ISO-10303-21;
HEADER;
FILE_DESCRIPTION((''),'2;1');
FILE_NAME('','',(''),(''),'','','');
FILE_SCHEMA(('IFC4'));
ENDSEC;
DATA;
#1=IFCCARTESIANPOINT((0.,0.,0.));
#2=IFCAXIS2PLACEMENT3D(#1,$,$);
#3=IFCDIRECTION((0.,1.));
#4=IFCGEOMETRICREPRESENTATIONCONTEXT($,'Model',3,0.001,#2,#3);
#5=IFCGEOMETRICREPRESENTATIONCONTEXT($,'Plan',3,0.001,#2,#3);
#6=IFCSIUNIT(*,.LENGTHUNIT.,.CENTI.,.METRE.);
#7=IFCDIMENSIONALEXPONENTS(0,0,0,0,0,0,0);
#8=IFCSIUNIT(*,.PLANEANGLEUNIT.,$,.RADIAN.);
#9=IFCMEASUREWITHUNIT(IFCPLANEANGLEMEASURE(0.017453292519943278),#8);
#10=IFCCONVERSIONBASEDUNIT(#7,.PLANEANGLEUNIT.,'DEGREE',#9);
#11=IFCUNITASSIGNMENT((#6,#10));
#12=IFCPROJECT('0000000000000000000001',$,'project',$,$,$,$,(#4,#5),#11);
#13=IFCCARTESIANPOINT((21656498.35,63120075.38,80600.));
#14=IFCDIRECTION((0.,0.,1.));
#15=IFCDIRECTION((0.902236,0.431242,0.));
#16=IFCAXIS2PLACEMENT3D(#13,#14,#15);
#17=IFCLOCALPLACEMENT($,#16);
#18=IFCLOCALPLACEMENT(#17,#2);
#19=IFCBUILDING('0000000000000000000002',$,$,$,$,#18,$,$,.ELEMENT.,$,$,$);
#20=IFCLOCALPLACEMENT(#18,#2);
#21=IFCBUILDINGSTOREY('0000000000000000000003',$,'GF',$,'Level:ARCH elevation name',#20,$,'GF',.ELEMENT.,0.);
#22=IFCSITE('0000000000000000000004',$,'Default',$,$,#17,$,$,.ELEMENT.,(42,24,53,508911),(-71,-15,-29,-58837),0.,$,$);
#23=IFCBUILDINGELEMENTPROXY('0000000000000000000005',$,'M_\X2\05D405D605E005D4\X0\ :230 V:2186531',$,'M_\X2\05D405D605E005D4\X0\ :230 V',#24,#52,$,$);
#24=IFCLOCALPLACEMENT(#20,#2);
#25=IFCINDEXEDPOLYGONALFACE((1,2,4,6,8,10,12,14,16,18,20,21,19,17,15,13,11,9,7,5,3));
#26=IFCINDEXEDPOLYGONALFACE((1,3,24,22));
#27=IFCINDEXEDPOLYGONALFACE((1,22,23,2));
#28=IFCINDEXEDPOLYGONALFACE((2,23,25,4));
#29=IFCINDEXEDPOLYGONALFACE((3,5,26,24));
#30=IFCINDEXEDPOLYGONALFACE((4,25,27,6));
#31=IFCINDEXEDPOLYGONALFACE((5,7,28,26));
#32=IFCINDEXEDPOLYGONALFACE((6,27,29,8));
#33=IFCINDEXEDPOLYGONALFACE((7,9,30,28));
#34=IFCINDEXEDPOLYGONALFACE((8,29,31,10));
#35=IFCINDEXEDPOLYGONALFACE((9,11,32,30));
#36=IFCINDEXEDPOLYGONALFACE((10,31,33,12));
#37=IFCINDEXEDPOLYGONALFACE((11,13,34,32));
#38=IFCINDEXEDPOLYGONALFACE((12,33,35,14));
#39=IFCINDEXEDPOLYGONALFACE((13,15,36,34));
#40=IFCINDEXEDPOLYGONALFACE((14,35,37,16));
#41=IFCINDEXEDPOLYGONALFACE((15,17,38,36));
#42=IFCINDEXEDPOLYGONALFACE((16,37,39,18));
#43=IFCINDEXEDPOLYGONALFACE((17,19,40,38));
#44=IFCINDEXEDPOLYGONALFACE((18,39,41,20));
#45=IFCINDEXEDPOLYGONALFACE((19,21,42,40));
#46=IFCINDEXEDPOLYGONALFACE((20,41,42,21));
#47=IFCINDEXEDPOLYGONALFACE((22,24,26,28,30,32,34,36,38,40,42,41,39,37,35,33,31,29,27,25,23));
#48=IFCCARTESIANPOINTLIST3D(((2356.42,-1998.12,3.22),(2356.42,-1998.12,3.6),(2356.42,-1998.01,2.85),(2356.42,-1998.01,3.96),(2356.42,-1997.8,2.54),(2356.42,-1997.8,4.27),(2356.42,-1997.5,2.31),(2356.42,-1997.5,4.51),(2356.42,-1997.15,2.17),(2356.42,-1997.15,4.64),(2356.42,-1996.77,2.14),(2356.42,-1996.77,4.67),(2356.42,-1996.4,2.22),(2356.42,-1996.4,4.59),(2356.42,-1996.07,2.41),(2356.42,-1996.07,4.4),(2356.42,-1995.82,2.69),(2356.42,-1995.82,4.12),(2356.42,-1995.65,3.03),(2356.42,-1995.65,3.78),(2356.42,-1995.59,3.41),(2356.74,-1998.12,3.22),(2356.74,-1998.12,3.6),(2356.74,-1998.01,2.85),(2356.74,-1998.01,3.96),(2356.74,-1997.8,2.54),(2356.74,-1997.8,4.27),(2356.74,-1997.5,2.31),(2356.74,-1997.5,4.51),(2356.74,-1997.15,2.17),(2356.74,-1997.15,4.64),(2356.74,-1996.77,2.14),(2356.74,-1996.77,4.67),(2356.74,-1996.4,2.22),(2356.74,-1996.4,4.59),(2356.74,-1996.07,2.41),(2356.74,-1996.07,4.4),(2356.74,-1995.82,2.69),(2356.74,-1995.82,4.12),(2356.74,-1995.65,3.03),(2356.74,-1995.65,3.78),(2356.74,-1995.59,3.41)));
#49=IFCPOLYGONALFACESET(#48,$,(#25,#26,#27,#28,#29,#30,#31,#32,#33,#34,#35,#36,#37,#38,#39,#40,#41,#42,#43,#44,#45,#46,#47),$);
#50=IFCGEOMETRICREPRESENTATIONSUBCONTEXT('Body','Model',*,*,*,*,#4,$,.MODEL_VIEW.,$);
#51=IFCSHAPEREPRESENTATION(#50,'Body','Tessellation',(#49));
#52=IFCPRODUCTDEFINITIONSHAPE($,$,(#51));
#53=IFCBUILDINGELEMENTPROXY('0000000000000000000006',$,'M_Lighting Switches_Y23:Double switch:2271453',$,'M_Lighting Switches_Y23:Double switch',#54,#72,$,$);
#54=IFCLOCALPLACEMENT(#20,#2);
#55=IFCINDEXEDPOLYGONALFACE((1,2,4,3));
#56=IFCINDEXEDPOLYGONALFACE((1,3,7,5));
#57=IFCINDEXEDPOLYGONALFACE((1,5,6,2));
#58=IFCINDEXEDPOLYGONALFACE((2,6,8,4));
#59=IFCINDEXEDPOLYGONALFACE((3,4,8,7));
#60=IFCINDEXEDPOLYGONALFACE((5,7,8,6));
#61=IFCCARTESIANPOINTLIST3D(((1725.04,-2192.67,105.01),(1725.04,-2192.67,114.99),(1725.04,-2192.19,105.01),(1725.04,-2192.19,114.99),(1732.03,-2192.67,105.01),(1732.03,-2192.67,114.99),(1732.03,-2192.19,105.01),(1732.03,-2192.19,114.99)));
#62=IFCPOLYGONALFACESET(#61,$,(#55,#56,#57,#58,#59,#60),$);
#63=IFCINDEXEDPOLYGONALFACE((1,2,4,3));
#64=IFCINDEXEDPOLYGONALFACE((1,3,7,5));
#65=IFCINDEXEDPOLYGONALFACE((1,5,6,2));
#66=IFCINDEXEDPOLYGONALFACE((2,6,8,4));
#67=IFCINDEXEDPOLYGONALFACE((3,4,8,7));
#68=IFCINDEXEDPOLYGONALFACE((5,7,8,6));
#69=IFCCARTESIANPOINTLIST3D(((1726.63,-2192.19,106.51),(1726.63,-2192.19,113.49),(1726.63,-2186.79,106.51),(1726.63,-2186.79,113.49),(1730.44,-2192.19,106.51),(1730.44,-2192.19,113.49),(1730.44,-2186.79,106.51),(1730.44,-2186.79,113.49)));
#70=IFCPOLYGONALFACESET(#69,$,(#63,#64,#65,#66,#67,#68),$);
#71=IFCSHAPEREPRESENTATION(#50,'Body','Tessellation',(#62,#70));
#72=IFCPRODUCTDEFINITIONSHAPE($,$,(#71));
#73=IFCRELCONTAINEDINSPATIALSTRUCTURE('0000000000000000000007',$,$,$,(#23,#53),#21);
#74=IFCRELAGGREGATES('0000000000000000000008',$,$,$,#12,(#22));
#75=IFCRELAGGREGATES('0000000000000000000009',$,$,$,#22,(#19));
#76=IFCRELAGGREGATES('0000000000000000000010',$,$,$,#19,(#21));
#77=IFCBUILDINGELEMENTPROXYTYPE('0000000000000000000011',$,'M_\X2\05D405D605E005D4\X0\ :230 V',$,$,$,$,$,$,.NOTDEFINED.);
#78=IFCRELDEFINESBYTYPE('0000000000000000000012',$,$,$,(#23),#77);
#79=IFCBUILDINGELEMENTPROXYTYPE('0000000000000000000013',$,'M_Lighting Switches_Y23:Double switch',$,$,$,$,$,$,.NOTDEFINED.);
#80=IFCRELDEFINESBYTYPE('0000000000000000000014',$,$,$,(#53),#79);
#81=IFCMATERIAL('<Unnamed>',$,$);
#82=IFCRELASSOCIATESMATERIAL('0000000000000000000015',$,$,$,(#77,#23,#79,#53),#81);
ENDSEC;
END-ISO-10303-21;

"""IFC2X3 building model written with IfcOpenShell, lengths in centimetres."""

from ifc_helpers import new_model, entity, si_unit, converted_unit, direction, frame, frame_2d, origin, place, context, subcontext, project, spatial, rectangle, circle, extrude, source, transform, mapped, material, type_object, type_shapes, element, save


model = new_model("IFC2X3")

# Units and contexts
model_context = context("Model", 3, precision=0.001, world=origin(), true_north=direction((0.0, 1.0)))
plan_context = context("Plan", 3, precision=0.001, world=origin(), true_north=direction((0.0, 1.0)))
body_context = subcontext(model_context, "Body", "Model", "MODEL_VIEW")
ifc_project = project(units=[si_unit("LENGTHUNIT", "METRE", prefix="CENTI"), converted_unit("PLANEANGLEUNIT", "DEGREE", entity("IfcPlaneAngleMeasure", 0.017453292519943278), si_unit("PLANEANGLEUNIT", "RADIAN"), dimensions=[0, 0, 0, 0, 0, 0, 0])], contexts=[model_context, plan_context])

# Site, building, storey
site_placement = place(None, frame((21656498.35, 63120075.38, 80600.0), z_axis=(0.0, 0.0, 1.0), x_axis=(0.902236, 0.431242, 0.0)))
site = spatial("IfcSite", under=ifc_project, at=site_placement, Name="Default", CompositionType="ELEMENT", RefLatitude=(42, 24, 53, 508911), RefLongitude=(-71, -15, -29, -58837), RefElevation=0.0)
building_placement = place(site_placement, origin())
building = spatial("IfcBuilding", under=site, at=building_placement, CompositionType="ELEMENT")
storey_placement = place(building_placement, origin())
storey = spatial("IfcBuildingStorey", under=building, at=storey_placement, Name="GF", ObjectType="Level:ARCH elevation name", LongName="GF", CompositionType="ELEMENT", Elevation=0.0)

# Building element proxies
ifc_material_1 = material(Name="<Unnamed>")
building_element_proxy_type_1 = type_object("IfcBuildingElementProxyType", Name="M_הזנה :230 V", PredefinedType="NOTDEFINED", material=ifc_material_1)
shared_shape_1 = source(origin(), body_context, "Body", "SweptSolid", [
    extrude(circle(Radius=1.27, at=frame_2d((0.0, 0.0), x_axis=(1.0, 0.0))), origin(), (0.0, 0.0, 1.0), 0.32),
])
type_shapes(building_element_proxy_type_1, [shared_shape_1])
for number, where, z_axis, x_axis, name in (
    (1, (2356.74, -1996.86, 3.41), (-1.0, 0.0, 0.0), (0.0, 1.0, 0.0), "M_הזנה :230 V:2186531"),
):
    element("IfcBuildingElementProxy", number, at=place(storey_placement, frame(where, z_axis=z_axis, x_axis=x_axis)), inside=storey, type_object=building_element_proxy_type_1, material=ifc_material_1, Name=name, ObjectType="M_הזנה :230 V", context=body_context, shape_type="MappedRepresentation", body=[
        mapped(shared_shape_1, transform((0.0, 0.0, 0.0), scale=1.0)),
    ])
building_element_proxy_type_2 = type_object("IfcBuildingElementProxyType", Name="M_Lighting Switches_Y23:Double switch", PredefinedType="NOTDEFINED", material=ifc_material_1)
shared_shape_2 = source(origin(), body_context, "Body", "SweptSolid", [
    extrude(rectangle(XDim=6.99, YDim=9.98, at=frame_2d((0.0, 0.0), x_axis=(1.0, 0.0))), frame((0.0, 0.0, 0.0), z_axis=(0.0, 0.0, 1.0), x_axis=(-1.0, 0.0, 0.0)), (0.0, 0.0, 1.0), 0.48),
    extrude(rectangle(XDim=3.81, YDim=6.98, at=frame_2d((0.0, 0.0), x_axis=(1.0, 0.0))), frame((0.0, 0.0, -5.4), z_axis=(0.0, 0.0, 1.0), x_axis=(-1.0, 0.0, 0.0)), (0.0, 0.0, 1.0), 5.4),
])
type_shapes(building_element_proxy_type_2, [shared_shape_2])
proxy_1_placement = place(storey_placement, frame((1728.53, -2192.19, 110.0), z_axis=(0.0, -1.0, 0.0), x_axis=(1.0, 0.0, 0.0)))
element("IfcBuildingElementProxy", 2, at=proxy_1_placement, inside=storey, type_object=building_element_proxy_type_2, material=ifc_material_1, Name="M_Lighting Switches_Y23:Double switch:2271453", ObjectType="M_Lighting Switches_Y23:Double switch", context=body_context, shape_type="MappedRepresentation", body=[
    mapped(shared_shape_2, transform((0.0, 0.0, 0.0), scale=1.0)),
])

save(model, "model.ifc")
